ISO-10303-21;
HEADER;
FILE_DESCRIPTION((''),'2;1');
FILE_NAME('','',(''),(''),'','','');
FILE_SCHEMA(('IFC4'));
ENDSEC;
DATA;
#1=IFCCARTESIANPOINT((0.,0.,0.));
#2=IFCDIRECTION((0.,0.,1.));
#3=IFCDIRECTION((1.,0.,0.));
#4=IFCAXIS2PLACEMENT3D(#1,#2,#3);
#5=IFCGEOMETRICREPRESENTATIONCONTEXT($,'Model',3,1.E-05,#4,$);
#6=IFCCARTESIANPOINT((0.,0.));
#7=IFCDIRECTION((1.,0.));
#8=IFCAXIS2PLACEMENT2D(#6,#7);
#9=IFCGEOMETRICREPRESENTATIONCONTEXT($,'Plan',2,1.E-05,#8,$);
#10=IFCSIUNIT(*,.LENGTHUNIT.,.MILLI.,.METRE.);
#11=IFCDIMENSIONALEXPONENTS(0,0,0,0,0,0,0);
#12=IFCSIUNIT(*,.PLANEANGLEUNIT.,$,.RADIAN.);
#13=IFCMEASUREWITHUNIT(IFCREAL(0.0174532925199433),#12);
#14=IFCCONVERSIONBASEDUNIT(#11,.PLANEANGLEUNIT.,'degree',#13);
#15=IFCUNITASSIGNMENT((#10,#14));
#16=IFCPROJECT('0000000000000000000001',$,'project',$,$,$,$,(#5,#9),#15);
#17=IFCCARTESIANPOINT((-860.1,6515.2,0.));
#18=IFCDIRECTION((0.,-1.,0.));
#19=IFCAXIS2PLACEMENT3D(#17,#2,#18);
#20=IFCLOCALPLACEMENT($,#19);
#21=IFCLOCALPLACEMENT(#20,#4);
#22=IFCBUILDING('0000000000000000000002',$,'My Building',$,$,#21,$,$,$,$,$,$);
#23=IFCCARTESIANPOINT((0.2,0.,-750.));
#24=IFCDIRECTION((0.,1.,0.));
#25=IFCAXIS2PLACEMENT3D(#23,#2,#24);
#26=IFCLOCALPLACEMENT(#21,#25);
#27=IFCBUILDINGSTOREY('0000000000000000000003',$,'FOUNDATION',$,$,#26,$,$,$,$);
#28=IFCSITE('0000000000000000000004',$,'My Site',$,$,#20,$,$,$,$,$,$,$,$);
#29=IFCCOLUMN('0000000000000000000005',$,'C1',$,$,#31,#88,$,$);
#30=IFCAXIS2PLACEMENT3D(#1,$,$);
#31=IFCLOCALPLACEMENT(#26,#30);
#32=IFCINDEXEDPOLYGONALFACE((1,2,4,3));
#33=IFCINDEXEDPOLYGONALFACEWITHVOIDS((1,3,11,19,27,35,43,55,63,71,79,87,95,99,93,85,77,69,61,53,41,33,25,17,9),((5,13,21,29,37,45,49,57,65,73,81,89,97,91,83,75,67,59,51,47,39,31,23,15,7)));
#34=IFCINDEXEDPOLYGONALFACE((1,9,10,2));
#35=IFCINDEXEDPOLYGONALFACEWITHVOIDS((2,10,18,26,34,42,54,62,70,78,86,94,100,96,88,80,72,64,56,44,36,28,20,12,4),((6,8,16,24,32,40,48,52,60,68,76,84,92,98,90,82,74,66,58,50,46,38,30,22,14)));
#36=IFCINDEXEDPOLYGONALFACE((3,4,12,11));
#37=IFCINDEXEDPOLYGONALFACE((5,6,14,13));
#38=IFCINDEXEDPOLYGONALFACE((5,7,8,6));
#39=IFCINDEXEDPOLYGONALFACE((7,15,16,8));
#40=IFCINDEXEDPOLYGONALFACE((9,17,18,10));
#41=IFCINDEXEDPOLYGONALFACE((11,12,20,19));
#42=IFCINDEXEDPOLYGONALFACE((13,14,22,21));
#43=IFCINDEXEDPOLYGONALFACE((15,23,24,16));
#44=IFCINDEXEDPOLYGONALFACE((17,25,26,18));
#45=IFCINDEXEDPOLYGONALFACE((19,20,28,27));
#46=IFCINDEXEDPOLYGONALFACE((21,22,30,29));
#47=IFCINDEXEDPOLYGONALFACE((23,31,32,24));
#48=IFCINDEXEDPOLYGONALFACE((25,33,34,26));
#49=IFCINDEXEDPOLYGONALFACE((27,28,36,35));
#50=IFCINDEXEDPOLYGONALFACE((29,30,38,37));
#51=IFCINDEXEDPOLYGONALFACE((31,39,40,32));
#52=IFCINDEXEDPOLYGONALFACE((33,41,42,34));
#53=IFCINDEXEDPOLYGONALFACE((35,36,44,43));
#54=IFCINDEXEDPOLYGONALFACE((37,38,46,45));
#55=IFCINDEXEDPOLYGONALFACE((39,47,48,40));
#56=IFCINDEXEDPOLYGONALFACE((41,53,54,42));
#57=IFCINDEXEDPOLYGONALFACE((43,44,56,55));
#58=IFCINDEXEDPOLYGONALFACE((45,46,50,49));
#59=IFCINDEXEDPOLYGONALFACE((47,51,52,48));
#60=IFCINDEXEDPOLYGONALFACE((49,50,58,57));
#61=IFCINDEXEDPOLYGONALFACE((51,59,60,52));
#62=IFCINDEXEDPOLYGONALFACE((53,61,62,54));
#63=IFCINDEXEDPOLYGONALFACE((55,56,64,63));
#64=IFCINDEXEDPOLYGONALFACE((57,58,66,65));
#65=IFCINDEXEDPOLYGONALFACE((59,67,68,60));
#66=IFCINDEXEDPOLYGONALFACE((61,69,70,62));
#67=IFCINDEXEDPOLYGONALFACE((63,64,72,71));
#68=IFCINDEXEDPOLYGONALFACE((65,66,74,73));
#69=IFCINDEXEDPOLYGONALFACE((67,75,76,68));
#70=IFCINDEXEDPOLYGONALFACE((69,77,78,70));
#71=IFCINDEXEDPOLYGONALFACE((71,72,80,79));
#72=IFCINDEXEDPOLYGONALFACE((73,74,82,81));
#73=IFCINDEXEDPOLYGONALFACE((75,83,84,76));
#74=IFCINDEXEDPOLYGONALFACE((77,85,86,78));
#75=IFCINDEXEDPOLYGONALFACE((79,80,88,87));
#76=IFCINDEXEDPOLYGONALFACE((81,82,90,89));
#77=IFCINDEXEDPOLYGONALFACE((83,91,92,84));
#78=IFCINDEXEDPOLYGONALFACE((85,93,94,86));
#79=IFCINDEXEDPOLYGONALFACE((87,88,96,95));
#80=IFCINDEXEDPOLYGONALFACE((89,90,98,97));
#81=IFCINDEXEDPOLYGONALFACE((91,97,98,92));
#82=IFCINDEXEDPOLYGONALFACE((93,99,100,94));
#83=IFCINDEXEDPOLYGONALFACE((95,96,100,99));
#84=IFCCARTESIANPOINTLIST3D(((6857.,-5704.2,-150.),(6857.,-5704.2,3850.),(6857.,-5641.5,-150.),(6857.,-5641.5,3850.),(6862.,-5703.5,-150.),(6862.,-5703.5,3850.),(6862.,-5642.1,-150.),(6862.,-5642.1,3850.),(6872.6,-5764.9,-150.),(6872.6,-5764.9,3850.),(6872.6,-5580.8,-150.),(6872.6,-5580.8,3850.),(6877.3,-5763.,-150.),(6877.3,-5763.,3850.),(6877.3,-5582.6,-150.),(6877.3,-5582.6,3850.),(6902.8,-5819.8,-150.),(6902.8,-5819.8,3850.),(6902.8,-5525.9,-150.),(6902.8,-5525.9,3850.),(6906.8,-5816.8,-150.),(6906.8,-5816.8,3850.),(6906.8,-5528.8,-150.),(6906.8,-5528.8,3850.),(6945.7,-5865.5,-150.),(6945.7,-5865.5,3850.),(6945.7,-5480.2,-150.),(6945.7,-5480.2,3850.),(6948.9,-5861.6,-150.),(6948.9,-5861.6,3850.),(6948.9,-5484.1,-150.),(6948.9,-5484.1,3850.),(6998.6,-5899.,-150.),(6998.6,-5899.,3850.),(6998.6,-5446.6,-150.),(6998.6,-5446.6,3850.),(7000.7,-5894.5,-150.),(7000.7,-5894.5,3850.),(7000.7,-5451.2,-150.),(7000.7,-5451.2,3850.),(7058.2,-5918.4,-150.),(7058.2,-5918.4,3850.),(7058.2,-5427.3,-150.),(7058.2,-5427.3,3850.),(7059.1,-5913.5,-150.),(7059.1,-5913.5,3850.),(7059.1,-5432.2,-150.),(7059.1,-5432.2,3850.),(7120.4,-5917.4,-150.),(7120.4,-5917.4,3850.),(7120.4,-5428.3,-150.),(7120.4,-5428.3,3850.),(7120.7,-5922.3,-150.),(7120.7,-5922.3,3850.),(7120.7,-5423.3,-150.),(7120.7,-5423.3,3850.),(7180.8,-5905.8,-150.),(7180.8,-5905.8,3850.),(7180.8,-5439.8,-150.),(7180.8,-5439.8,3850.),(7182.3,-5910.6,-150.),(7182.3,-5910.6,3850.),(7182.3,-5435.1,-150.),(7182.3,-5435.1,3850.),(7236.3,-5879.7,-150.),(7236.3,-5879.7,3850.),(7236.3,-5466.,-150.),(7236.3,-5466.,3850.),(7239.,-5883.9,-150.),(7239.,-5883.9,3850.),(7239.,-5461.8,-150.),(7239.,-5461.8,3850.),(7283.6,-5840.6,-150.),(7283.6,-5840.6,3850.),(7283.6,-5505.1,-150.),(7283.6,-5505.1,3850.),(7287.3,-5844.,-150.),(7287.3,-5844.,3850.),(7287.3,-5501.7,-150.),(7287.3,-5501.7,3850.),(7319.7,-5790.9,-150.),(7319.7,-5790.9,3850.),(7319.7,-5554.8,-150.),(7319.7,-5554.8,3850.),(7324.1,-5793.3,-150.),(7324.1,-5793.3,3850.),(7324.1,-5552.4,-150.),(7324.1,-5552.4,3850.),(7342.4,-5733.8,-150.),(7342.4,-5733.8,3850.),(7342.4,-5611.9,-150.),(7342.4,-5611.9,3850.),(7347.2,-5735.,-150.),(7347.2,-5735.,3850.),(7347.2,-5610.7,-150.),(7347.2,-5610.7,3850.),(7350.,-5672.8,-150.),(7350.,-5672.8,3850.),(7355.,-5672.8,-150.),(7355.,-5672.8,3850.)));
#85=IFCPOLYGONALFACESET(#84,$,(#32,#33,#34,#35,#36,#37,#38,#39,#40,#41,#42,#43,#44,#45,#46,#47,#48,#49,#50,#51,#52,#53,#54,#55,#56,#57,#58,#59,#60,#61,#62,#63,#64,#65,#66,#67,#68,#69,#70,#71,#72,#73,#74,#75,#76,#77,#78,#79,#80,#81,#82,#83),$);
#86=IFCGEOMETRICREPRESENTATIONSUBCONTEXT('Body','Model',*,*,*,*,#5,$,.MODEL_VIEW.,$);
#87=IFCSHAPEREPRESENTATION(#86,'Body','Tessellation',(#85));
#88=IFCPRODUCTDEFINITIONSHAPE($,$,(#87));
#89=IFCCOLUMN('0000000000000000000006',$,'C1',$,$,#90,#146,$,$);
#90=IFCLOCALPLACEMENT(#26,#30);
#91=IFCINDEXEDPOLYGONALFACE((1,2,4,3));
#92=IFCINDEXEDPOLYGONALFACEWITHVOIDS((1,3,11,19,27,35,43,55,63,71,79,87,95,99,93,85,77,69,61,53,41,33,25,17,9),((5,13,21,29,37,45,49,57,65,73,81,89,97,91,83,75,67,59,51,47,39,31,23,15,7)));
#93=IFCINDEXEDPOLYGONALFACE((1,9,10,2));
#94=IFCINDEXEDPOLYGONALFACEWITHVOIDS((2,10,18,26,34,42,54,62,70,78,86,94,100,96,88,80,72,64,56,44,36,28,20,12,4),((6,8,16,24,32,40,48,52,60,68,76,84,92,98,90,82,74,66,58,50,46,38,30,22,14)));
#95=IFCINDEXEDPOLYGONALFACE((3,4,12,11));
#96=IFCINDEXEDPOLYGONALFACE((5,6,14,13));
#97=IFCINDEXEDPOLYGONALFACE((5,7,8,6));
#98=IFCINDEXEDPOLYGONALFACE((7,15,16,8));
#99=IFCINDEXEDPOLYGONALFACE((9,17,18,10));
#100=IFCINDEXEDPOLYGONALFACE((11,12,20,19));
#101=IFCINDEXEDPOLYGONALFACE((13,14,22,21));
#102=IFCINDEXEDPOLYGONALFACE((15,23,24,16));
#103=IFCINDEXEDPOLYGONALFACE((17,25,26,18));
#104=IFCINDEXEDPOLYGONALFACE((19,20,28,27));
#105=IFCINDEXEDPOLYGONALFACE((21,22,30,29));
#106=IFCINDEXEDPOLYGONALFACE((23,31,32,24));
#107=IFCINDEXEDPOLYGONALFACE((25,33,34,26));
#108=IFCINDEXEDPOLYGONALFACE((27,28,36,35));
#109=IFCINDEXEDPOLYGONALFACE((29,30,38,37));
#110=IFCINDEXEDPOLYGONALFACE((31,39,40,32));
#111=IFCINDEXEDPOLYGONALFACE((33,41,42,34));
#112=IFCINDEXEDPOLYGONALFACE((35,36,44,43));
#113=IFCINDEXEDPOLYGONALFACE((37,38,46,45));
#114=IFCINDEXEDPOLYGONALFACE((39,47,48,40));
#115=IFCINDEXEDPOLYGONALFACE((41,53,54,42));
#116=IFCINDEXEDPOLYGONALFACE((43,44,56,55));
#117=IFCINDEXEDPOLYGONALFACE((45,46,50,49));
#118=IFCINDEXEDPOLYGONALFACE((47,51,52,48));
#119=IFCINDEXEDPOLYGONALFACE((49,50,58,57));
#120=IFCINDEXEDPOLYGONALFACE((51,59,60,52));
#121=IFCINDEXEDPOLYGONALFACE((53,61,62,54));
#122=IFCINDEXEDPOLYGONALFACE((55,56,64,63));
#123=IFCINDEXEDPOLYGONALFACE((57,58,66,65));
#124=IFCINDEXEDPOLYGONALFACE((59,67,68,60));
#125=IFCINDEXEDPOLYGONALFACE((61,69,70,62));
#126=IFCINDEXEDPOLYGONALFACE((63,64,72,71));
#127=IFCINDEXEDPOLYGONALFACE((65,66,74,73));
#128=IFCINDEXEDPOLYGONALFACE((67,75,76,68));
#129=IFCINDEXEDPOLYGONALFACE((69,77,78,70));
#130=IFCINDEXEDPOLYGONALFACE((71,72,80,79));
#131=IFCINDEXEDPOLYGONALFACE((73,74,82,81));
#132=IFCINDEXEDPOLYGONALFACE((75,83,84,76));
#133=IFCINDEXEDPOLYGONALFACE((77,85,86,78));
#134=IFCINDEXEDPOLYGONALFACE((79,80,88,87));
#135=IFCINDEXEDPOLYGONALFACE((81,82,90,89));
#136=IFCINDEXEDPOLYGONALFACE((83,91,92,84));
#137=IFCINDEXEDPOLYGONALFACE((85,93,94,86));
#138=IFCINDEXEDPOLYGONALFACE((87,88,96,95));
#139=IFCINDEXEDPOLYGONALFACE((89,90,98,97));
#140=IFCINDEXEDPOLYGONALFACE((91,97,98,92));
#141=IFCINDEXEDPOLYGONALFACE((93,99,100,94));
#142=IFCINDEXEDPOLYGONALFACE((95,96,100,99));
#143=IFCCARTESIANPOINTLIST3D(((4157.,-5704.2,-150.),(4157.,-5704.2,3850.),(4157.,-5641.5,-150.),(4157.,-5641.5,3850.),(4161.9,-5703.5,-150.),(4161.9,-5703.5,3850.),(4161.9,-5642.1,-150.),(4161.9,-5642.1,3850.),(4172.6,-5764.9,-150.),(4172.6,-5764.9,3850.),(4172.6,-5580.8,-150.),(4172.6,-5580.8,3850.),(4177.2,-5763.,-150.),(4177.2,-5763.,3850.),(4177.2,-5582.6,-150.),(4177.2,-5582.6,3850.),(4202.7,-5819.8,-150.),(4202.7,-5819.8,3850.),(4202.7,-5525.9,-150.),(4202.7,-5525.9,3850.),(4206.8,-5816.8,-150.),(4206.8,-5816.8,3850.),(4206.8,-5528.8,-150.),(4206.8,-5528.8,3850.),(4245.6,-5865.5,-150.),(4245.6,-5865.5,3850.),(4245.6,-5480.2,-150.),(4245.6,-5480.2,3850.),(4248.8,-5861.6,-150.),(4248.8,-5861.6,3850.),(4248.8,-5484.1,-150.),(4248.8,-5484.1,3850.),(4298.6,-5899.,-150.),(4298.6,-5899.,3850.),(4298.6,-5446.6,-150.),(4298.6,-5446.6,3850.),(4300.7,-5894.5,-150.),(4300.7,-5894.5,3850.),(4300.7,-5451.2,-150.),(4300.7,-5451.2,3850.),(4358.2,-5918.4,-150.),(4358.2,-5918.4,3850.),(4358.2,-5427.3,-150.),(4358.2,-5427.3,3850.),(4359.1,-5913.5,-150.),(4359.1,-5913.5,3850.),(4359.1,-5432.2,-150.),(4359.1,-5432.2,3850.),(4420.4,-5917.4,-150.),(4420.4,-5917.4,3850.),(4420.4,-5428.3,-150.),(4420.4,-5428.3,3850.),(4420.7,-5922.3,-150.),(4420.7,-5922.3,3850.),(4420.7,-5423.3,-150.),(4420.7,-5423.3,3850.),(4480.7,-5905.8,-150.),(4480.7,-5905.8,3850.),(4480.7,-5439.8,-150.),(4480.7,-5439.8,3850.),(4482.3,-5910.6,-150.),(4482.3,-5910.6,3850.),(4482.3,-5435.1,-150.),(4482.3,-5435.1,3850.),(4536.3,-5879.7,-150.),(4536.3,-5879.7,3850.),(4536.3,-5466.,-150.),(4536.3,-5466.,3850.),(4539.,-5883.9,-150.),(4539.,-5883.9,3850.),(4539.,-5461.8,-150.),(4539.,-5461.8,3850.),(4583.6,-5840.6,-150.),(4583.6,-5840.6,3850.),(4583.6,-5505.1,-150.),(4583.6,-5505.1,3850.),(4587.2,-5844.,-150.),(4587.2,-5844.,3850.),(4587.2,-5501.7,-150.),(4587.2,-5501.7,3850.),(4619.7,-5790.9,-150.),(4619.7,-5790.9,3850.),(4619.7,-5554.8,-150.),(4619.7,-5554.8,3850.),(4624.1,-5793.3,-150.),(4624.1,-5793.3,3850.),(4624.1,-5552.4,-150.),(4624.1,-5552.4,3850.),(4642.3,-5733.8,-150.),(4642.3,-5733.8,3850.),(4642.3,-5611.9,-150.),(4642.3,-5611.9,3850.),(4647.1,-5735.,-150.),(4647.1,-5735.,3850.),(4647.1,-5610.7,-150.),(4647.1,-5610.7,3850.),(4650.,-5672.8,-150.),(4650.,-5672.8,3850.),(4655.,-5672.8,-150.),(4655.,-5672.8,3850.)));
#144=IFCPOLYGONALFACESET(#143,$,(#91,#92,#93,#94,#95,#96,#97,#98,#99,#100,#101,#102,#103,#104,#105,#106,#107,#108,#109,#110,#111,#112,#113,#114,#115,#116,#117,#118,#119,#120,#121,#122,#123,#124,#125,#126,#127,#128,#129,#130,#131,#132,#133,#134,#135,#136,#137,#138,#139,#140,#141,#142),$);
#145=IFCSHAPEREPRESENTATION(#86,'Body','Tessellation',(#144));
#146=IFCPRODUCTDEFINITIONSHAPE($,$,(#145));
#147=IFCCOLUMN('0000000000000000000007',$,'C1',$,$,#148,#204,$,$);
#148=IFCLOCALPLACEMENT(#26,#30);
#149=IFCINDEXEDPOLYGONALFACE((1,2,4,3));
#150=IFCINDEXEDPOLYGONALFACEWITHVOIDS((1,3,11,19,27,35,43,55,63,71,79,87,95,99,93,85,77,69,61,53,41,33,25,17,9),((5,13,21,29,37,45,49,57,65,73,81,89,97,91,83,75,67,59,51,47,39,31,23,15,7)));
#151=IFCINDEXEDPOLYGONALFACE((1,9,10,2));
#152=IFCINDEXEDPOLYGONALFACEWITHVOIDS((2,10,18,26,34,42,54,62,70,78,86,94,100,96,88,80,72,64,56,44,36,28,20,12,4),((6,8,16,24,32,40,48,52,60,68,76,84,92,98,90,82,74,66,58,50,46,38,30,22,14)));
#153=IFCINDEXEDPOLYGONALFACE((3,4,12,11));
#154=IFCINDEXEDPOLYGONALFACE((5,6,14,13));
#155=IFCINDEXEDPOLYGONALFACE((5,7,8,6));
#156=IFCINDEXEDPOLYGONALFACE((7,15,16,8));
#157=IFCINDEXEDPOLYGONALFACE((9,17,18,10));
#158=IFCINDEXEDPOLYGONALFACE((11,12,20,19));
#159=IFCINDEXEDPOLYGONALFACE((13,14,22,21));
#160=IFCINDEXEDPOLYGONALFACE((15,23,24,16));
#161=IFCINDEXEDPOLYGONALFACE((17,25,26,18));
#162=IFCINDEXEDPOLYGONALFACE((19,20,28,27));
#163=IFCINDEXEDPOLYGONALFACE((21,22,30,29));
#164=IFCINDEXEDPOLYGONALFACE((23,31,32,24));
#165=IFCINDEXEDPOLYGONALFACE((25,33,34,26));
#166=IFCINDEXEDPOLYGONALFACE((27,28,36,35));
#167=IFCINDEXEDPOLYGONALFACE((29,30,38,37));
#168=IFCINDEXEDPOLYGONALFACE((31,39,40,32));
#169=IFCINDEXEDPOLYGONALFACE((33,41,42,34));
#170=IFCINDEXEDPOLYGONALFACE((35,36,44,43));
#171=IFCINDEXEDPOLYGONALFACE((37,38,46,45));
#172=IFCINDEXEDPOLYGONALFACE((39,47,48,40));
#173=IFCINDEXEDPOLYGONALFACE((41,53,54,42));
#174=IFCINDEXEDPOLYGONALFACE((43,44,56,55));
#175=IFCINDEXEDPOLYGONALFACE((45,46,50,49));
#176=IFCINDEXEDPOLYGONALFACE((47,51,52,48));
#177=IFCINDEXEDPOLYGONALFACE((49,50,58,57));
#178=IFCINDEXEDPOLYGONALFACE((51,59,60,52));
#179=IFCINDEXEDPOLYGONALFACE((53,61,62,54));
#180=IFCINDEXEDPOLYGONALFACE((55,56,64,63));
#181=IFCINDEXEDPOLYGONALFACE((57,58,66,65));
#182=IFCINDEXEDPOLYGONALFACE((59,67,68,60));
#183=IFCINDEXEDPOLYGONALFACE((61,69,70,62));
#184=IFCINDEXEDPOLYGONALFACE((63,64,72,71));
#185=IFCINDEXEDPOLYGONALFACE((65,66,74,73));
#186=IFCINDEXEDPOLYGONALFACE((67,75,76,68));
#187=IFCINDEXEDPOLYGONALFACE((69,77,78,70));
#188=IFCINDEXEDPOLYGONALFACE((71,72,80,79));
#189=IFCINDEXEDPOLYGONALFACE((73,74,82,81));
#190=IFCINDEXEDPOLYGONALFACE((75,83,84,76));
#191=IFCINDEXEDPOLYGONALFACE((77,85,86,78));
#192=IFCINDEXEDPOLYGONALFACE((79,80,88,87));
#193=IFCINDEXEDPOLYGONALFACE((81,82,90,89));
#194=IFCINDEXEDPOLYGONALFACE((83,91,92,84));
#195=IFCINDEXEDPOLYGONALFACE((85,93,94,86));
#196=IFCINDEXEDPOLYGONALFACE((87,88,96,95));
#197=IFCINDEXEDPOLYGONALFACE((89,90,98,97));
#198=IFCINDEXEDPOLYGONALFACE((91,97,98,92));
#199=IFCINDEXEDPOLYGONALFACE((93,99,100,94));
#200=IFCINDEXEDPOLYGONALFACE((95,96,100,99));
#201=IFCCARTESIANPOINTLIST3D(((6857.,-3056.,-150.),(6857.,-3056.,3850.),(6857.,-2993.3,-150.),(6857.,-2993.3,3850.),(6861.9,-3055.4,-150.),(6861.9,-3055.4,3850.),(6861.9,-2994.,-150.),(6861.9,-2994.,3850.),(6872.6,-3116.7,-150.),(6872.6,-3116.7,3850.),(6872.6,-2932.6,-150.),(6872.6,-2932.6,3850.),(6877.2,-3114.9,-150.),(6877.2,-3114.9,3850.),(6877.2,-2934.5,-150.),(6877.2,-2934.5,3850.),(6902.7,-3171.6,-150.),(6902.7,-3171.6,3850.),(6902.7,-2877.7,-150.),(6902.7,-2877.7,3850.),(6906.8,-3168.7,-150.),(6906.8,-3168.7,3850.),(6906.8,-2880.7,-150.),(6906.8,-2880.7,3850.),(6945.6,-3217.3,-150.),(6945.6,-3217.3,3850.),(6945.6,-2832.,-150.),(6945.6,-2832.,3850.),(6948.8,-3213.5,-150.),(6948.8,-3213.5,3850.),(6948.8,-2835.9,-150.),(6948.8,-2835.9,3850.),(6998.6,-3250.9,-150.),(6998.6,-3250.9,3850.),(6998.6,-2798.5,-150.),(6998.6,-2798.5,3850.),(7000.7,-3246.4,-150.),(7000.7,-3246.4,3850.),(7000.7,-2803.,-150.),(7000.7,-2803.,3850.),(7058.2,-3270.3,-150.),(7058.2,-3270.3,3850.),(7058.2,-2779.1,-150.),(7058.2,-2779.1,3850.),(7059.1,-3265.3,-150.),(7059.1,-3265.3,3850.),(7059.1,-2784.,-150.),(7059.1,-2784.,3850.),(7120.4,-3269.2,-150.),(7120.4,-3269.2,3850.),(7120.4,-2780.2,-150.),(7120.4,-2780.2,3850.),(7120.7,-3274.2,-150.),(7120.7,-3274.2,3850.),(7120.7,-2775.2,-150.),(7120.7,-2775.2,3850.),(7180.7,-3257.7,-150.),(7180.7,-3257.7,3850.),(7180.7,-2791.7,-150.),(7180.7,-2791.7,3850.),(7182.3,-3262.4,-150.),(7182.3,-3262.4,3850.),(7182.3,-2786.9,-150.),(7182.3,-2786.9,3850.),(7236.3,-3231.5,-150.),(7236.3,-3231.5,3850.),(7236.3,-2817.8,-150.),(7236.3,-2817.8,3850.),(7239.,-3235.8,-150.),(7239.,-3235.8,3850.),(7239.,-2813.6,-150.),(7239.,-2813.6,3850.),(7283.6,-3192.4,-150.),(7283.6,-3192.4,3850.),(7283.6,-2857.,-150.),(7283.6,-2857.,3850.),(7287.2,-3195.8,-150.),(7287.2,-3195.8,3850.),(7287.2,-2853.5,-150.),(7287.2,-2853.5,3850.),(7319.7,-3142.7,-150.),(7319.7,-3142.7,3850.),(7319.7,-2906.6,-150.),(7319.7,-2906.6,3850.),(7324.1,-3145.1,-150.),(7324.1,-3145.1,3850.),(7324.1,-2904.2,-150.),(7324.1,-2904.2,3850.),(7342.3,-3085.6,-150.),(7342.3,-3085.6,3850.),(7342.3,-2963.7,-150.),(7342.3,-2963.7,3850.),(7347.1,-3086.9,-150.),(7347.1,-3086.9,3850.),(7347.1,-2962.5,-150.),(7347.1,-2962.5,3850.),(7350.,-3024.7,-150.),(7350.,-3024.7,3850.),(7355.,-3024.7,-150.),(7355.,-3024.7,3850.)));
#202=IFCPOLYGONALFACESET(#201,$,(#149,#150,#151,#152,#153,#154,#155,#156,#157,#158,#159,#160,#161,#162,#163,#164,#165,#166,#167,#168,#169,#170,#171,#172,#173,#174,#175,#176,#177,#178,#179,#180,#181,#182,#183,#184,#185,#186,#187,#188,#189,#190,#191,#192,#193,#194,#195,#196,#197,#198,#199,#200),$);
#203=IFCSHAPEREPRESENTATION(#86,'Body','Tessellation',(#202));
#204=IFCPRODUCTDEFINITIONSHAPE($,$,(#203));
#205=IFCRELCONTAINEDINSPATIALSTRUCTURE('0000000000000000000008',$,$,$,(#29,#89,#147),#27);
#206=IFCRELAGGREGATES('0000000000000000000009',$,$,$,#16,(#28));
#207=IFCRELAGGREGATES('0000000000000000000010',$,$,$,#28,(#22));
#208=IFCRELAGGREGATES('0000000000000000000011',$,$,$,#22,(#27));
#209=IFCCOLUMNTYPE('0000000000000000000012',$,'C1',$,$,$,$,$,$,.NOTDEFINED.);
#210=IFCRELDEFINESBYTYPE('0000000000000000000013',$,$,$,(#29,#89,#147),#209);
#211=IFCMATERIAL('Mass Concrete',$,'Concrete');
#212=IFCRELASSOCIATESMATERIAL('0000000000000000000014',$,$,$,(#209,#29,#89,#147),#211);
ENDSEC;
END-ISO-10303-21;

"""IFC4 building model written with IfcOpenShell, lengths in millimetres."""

from ifc_helpers import new_model, entity, si_unit, converted_unit, frame, origin_with_axes, origin_2d_with_axis, place, context, subcontext, project, spatial, rectangle, hollow_circle, extrude, material, material_profile, profile_set, profile_usage, type_object, element, save


model = new_model("IFC4")

# Units and contexts
model_context = context("Model", 3, precision=1e-05, world=origin_with_axes())
plan_context = context("Plan", 2, precision=1e-05, world=origin_2d_with_axis())
body_context = subcontext(model_context, "Body", "Model", "MODEL_VIEW")
ifc_project = project(units=[si_unit("LENGTHUNIT", "METRE", prefix="MILLI"), converted_unit("PLANEANGLEUNIT", "degree", entity("IfcReal", 0.0174532925199433), si_unit("PLANEANGLEUNIT", "RADIAN"), dimensions=[0, 0, 0, 0, 0, 0, 0])], contexts=[model_context, plan_context])

# Site, building, storey
site_placement = place(None, frame((-860.1, 6515.2, 0.0), z_axis=(0.0, 0.0, 1.0), x_axis=(0.0, -1.0, 0.0)))
site = spatial("IfcSite", under=ifc_project, at=site_placement, Name="My Site")
building_placement = place(site_placement, frame((0.0, 0.0, 0.0), z_axis=(0.0, 0.0, 1.0), x_axis=(1.0, 0.0, 0.0)))
building = spatial("IfcBuilding", under=site, at=building_placement, Name="My Building")
storey_placement = place(building_placement, frame((0.2, 0.0, -750.0), z_axis=(0.0, 0.0, 1.0), x_axis=(0.0, 1.0, 0.0)))
storey = spatial("IfcBuildingStorey", under=building, at=storey_placement, Name="FOUNDATION")

# Shared definitions
ifc_material_1 = material(Name="Mass Concrete", Category="Concrete")

# Columns
ifc_material_profile = material_profile(ifc_material_1, rectangle(XDim=150.0, YDim=150.0), Name="Square Column", Category="Structure", Priority=1)
ifc_profile_set = profile_set([ifc_material_profile], Name="RC_COL_150x150")
column_type = type_object("IfcColumnType", Name="C1", PredefinedType="NOTDEFINED", material=ifc_profile_set)
ifc_profile_usage_1 = profile_usage(ifc_profile_set, cardinal=5)
column_1_placement = place(storey_placement, frame((7105.0, -5672.8, -150.0), z_axis=(0.0, 0.0, 1.0), x_axis=(1.0, 0.0, 0.0)))
element("IfcColumn", 1, at=column_1_placement, inside=storey, type_object=column_type, material=ifc_profile_usage_1, Name="C1", context=body_context, shape_type="SweptSolid", body=[
    extrude(hollow_circle(Radius=250.0, WallThickness=5.0), origin_with_axes(), (0.0, 0.0, 1.0), 4000.0),
])
ifc_profile_usage_2 = profile_usage(ifc_profile_set, cardinal=5)
column_2_placement = place(storey_placement, frame((4405.0, -5672.8, -150.0), z_axis=(0.0, 0.0, 1.0), x_axis=(1.0, 0.0, 0.0)))
element("IfcColumn", 2, at=column_2_placement, inside=storey, type_object=column_type, material=ifc_profile_usage_2, Name="C1", context=body_context, shape_type="SweptSolid", body=[
    extrude(hollow_circle(Radius=250.0, WallThickness=5.0), origin_with_axes(), (0.0, 0.0, 1.0), 4000.0),
])
ifc_profile_usage_3 = profile_usage(ifc_profile_set, cardinal=5)
column_3_placement = place(storey_placement, frame((7105.0, -3024.7, -150.0), z_axis=(0.0, 0.0, 1.0), x_axis=(1.0, 0.0, 0.0)))
element("IfcColumn", 3, at=column_3_placement, inside=storey, type_object=column_type, material=ifc_profile_usage_3, Name="C1", context=body_context, shape_type="SweptSolid", body=[
    extrude(hollow_circle(Radius=250.0, WallThickness=5.0), origin_with_axes(), (0.0, 0.0, 1.0), 4000.0),
])

save(model, "model.ifc")
